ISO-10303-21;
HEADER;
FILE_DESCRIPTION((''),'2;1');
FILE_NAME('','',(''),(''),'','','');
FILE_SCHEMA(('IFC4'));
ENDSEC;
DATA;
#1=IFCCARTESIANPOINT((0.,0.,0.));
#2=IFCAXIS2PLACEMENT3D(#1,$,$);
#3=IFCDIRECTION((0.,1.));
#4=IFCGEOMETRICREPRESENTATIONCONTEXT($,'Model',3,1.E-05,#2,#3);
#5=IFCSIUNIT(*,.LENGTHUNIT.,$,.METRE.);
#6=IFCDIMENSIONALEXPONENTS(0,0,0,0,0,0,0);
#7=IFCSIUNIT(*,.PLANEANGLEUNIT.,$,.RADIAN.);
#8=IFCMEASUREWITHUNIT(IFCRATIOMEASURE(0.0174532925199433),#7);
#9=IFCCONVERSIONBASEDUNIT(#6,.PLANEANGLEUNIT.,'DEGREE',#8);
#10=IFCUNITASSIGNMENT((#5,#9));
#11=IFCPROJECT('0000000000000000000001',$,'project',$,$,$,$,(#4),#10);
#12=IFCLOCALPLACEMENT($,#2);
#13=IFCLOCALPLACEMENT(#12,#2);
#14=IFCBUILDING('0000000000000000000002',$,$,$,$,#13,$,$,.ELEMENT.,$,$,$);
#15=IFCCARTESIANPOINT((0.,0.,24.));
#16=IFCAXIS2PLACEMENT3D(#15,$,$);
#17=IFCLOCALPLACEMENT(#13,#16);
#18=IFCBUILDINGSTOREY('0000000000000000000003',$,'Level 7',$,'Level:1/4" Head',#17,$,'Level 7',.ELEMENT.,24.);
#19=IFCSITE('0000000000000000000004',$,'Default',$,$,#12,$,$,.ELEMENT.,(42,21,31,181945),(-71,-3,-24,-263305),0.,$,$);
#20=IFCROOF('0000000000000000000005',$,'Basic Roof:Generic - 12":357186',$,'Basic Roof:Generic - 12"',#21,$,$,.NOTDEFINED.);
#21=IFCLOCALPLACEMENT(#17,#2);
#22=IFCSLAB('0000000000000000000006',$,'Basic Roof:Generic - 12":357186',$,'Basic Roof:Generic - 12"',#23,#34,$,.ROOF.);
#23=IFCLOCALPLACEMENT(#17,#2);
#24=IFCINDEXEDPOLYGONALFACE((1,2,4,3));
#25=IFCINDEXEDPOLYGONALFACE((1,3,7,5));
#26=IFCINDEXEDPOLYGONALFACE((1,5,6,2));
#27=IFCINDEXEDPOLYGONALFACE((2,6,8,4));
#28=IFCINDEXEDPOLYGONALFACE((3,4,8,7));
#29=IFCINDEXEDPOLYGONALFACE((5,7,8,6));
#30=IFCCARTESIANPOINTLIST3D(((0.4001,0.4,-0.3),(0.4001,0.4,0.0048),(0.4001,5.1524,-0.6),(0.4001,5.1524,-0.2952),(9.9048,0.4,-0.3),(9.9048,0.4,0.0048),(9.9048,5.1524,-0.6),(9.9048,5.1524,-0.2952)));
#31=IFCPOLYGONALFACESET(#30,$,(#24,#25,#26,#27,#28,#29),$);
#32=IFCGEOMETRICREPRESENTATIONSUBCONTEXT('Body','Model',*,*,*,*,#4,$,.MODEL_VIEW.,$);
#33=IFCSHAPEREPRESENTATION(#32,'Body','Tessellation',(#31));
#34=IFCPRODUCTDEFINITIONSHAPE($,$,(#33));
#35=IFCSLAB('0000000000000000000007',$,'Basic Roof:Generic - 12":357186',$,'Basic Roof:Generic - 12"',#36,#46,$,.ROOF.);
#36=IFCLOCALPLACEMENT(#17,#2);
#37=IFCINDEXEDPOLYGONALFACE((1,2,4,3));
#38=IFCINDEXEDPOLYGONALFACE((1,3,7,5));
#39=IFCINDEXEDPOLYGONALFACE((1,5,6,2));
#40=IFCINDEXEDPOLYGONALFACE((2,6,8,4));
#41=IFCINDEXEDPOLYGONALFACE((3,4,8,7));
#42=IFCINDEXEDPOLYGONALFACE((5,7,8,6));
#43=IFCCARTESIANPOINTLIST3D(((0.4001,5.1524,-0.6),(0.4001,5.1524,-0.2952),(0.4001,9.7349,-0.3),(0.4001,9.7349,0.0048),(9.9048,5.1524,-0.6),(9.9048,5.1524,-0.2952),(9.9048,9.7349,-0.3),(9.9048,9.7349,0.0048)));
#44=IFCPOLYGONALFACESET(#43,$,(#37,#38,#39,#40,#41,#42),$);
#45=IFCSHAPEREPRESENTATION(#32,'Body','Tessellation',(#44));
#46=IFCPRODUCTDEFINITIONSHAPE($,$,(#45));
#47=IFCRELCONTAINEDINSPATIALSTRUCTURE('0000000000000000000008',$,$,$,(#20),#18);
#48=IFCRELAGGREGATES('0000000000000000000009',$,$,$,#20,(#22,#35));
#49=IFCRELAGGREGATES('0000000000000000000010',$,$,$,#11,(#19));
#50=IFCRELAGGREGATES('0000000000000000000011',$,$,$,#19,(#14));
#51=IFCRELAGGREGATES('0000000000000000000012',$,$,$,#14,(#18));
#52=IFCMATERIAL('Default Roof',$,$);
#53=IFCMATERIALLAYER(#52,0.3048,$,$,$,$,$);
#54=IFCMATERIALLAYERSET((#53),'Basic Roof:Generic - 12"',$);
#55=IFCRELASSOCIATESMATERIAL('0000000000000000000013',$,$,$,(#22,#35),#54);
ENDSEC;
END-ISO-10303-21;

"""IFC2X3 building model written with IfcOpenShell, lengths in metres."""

from ifc_helpers import new_model, entity, si_unit, converted_unit, direction, frame, frame_2d, origin, place, context, subcontext, project, spatial, rectangle, extrude, material, layer, layer_set, element, aggregate, save


model = new_model("IFC2X3")

# Units and contexts
model_context = context("Model", 3, precision=1e-05, world=origin(), true_north=direction((0.0, 1.0)))
body_context = subcontext(model_context, "Body", "Model", "MODEL_VIEW")
ifc_project = project(units=[si_unit("LENGTHUNIT", "METRE"), converted_unit("PLANEANGLEUNIT", "DEGREE", entity("IfcRatioMeasure", 0.0174532925199433), si_unit("PLANEANGLEUNIT", "RADIAN"), dimensions=[0, 0, 0, 0, 0, 0, 0])], contexts=[model_context])

# Site, building, storey
site_placement = place(None, origin())
site = spatial("IfcSite", under=ifc_project, at=site_placement, Name="Default", CompositionType="ELEMENT", RefLatitude=(42, 21, 31, 181945), RefLongitude=(-71, -3, -24, -263305), RefElevation=0.0)
building_placement = place(site_placement, origin())
building = spatial("IfcBuilding", under=site, at=building_placement, CompositionType="ELEMENT")
storey_placement = place(building_placement, frame((0.0, 0.0, 24.0)))
storey = spatial("IfcBuildingStorey", under=building, at=storey_placement, Name="Level 7", ObjectType="Level:1/4\" Head", LongName="Level 7", CompositionType="ELEMENT", Elevation=24.0)

# Roof, slabs
roof_placement = place(storey_placement, frame((0.4001, 0.4, -0.6)))
roof = element("IfcRoof", 1, at=roof_placement, inside=storey, Name="Basic Roof:Generic - 12\":357186", ObjectType="Basic Roof:Generic - 12\"", ShapeType="NOTDEFINED")
ifc_material = material(Name="Default Roof")
ifc_layer = layer(ifc_material, 0.3048)
ifc_layer_set = layer_set([ifc_layer], Name="Basic Roof:Generic - 12\"")
slab_1_placement = place(roof_placement, origin())
slab_1 = element("IfcSlab", 2, at=slab_1_placement, material=ifc_layer_set, Name="Basic Roof:Generic - 12\":357186", ObjectType="Basic Roof:Generic - 12\"", PredefinedType="ROOF", context=body_context, shape_type="SweptSolid", body=[
    extrude(rectangle(XDim=9.5047, YDim=4.7618, at=frame_2d((0.0, 0.0), x_axis=(1.0, 0.0))), frame((4.7524, 2.3762, 0.15), z_axis=(0.0, 0.063001, 0.998013), x_axis=(1.0, 0.0, 0.0)), (0.0, -0.063001, 0.998013), 0.3048),
])
slab_2_placement = place(roof_placement, origin())
slab_2 = element("IfcSlab", 3, at=slab_2_placement, material=ifc_layer_set, Name="Basic Roof:Generic - 12\":357186", ObjectType="Basic Roof:Generic - 12\"", PredefinedType="ROOF", context=body_context, shape_type="SweptSolid", body=[
    extrude(rectangle(XDim=4.5923, YDim=9.5047, at=frame_2d((0.0, 0.0), x_axis=(0.0, -1.0))), frame((4.7524, 7.0436, 0.15), z_axis=(0.0, -0.065327, 0.997864), x_axis=(1.0, 0.0, 0.0)), (0.0, 0.065327, 0.997864), 0.3048),
])
aggregate(roof, [slab_1, slab_2])

save(model, "model.ifc")
